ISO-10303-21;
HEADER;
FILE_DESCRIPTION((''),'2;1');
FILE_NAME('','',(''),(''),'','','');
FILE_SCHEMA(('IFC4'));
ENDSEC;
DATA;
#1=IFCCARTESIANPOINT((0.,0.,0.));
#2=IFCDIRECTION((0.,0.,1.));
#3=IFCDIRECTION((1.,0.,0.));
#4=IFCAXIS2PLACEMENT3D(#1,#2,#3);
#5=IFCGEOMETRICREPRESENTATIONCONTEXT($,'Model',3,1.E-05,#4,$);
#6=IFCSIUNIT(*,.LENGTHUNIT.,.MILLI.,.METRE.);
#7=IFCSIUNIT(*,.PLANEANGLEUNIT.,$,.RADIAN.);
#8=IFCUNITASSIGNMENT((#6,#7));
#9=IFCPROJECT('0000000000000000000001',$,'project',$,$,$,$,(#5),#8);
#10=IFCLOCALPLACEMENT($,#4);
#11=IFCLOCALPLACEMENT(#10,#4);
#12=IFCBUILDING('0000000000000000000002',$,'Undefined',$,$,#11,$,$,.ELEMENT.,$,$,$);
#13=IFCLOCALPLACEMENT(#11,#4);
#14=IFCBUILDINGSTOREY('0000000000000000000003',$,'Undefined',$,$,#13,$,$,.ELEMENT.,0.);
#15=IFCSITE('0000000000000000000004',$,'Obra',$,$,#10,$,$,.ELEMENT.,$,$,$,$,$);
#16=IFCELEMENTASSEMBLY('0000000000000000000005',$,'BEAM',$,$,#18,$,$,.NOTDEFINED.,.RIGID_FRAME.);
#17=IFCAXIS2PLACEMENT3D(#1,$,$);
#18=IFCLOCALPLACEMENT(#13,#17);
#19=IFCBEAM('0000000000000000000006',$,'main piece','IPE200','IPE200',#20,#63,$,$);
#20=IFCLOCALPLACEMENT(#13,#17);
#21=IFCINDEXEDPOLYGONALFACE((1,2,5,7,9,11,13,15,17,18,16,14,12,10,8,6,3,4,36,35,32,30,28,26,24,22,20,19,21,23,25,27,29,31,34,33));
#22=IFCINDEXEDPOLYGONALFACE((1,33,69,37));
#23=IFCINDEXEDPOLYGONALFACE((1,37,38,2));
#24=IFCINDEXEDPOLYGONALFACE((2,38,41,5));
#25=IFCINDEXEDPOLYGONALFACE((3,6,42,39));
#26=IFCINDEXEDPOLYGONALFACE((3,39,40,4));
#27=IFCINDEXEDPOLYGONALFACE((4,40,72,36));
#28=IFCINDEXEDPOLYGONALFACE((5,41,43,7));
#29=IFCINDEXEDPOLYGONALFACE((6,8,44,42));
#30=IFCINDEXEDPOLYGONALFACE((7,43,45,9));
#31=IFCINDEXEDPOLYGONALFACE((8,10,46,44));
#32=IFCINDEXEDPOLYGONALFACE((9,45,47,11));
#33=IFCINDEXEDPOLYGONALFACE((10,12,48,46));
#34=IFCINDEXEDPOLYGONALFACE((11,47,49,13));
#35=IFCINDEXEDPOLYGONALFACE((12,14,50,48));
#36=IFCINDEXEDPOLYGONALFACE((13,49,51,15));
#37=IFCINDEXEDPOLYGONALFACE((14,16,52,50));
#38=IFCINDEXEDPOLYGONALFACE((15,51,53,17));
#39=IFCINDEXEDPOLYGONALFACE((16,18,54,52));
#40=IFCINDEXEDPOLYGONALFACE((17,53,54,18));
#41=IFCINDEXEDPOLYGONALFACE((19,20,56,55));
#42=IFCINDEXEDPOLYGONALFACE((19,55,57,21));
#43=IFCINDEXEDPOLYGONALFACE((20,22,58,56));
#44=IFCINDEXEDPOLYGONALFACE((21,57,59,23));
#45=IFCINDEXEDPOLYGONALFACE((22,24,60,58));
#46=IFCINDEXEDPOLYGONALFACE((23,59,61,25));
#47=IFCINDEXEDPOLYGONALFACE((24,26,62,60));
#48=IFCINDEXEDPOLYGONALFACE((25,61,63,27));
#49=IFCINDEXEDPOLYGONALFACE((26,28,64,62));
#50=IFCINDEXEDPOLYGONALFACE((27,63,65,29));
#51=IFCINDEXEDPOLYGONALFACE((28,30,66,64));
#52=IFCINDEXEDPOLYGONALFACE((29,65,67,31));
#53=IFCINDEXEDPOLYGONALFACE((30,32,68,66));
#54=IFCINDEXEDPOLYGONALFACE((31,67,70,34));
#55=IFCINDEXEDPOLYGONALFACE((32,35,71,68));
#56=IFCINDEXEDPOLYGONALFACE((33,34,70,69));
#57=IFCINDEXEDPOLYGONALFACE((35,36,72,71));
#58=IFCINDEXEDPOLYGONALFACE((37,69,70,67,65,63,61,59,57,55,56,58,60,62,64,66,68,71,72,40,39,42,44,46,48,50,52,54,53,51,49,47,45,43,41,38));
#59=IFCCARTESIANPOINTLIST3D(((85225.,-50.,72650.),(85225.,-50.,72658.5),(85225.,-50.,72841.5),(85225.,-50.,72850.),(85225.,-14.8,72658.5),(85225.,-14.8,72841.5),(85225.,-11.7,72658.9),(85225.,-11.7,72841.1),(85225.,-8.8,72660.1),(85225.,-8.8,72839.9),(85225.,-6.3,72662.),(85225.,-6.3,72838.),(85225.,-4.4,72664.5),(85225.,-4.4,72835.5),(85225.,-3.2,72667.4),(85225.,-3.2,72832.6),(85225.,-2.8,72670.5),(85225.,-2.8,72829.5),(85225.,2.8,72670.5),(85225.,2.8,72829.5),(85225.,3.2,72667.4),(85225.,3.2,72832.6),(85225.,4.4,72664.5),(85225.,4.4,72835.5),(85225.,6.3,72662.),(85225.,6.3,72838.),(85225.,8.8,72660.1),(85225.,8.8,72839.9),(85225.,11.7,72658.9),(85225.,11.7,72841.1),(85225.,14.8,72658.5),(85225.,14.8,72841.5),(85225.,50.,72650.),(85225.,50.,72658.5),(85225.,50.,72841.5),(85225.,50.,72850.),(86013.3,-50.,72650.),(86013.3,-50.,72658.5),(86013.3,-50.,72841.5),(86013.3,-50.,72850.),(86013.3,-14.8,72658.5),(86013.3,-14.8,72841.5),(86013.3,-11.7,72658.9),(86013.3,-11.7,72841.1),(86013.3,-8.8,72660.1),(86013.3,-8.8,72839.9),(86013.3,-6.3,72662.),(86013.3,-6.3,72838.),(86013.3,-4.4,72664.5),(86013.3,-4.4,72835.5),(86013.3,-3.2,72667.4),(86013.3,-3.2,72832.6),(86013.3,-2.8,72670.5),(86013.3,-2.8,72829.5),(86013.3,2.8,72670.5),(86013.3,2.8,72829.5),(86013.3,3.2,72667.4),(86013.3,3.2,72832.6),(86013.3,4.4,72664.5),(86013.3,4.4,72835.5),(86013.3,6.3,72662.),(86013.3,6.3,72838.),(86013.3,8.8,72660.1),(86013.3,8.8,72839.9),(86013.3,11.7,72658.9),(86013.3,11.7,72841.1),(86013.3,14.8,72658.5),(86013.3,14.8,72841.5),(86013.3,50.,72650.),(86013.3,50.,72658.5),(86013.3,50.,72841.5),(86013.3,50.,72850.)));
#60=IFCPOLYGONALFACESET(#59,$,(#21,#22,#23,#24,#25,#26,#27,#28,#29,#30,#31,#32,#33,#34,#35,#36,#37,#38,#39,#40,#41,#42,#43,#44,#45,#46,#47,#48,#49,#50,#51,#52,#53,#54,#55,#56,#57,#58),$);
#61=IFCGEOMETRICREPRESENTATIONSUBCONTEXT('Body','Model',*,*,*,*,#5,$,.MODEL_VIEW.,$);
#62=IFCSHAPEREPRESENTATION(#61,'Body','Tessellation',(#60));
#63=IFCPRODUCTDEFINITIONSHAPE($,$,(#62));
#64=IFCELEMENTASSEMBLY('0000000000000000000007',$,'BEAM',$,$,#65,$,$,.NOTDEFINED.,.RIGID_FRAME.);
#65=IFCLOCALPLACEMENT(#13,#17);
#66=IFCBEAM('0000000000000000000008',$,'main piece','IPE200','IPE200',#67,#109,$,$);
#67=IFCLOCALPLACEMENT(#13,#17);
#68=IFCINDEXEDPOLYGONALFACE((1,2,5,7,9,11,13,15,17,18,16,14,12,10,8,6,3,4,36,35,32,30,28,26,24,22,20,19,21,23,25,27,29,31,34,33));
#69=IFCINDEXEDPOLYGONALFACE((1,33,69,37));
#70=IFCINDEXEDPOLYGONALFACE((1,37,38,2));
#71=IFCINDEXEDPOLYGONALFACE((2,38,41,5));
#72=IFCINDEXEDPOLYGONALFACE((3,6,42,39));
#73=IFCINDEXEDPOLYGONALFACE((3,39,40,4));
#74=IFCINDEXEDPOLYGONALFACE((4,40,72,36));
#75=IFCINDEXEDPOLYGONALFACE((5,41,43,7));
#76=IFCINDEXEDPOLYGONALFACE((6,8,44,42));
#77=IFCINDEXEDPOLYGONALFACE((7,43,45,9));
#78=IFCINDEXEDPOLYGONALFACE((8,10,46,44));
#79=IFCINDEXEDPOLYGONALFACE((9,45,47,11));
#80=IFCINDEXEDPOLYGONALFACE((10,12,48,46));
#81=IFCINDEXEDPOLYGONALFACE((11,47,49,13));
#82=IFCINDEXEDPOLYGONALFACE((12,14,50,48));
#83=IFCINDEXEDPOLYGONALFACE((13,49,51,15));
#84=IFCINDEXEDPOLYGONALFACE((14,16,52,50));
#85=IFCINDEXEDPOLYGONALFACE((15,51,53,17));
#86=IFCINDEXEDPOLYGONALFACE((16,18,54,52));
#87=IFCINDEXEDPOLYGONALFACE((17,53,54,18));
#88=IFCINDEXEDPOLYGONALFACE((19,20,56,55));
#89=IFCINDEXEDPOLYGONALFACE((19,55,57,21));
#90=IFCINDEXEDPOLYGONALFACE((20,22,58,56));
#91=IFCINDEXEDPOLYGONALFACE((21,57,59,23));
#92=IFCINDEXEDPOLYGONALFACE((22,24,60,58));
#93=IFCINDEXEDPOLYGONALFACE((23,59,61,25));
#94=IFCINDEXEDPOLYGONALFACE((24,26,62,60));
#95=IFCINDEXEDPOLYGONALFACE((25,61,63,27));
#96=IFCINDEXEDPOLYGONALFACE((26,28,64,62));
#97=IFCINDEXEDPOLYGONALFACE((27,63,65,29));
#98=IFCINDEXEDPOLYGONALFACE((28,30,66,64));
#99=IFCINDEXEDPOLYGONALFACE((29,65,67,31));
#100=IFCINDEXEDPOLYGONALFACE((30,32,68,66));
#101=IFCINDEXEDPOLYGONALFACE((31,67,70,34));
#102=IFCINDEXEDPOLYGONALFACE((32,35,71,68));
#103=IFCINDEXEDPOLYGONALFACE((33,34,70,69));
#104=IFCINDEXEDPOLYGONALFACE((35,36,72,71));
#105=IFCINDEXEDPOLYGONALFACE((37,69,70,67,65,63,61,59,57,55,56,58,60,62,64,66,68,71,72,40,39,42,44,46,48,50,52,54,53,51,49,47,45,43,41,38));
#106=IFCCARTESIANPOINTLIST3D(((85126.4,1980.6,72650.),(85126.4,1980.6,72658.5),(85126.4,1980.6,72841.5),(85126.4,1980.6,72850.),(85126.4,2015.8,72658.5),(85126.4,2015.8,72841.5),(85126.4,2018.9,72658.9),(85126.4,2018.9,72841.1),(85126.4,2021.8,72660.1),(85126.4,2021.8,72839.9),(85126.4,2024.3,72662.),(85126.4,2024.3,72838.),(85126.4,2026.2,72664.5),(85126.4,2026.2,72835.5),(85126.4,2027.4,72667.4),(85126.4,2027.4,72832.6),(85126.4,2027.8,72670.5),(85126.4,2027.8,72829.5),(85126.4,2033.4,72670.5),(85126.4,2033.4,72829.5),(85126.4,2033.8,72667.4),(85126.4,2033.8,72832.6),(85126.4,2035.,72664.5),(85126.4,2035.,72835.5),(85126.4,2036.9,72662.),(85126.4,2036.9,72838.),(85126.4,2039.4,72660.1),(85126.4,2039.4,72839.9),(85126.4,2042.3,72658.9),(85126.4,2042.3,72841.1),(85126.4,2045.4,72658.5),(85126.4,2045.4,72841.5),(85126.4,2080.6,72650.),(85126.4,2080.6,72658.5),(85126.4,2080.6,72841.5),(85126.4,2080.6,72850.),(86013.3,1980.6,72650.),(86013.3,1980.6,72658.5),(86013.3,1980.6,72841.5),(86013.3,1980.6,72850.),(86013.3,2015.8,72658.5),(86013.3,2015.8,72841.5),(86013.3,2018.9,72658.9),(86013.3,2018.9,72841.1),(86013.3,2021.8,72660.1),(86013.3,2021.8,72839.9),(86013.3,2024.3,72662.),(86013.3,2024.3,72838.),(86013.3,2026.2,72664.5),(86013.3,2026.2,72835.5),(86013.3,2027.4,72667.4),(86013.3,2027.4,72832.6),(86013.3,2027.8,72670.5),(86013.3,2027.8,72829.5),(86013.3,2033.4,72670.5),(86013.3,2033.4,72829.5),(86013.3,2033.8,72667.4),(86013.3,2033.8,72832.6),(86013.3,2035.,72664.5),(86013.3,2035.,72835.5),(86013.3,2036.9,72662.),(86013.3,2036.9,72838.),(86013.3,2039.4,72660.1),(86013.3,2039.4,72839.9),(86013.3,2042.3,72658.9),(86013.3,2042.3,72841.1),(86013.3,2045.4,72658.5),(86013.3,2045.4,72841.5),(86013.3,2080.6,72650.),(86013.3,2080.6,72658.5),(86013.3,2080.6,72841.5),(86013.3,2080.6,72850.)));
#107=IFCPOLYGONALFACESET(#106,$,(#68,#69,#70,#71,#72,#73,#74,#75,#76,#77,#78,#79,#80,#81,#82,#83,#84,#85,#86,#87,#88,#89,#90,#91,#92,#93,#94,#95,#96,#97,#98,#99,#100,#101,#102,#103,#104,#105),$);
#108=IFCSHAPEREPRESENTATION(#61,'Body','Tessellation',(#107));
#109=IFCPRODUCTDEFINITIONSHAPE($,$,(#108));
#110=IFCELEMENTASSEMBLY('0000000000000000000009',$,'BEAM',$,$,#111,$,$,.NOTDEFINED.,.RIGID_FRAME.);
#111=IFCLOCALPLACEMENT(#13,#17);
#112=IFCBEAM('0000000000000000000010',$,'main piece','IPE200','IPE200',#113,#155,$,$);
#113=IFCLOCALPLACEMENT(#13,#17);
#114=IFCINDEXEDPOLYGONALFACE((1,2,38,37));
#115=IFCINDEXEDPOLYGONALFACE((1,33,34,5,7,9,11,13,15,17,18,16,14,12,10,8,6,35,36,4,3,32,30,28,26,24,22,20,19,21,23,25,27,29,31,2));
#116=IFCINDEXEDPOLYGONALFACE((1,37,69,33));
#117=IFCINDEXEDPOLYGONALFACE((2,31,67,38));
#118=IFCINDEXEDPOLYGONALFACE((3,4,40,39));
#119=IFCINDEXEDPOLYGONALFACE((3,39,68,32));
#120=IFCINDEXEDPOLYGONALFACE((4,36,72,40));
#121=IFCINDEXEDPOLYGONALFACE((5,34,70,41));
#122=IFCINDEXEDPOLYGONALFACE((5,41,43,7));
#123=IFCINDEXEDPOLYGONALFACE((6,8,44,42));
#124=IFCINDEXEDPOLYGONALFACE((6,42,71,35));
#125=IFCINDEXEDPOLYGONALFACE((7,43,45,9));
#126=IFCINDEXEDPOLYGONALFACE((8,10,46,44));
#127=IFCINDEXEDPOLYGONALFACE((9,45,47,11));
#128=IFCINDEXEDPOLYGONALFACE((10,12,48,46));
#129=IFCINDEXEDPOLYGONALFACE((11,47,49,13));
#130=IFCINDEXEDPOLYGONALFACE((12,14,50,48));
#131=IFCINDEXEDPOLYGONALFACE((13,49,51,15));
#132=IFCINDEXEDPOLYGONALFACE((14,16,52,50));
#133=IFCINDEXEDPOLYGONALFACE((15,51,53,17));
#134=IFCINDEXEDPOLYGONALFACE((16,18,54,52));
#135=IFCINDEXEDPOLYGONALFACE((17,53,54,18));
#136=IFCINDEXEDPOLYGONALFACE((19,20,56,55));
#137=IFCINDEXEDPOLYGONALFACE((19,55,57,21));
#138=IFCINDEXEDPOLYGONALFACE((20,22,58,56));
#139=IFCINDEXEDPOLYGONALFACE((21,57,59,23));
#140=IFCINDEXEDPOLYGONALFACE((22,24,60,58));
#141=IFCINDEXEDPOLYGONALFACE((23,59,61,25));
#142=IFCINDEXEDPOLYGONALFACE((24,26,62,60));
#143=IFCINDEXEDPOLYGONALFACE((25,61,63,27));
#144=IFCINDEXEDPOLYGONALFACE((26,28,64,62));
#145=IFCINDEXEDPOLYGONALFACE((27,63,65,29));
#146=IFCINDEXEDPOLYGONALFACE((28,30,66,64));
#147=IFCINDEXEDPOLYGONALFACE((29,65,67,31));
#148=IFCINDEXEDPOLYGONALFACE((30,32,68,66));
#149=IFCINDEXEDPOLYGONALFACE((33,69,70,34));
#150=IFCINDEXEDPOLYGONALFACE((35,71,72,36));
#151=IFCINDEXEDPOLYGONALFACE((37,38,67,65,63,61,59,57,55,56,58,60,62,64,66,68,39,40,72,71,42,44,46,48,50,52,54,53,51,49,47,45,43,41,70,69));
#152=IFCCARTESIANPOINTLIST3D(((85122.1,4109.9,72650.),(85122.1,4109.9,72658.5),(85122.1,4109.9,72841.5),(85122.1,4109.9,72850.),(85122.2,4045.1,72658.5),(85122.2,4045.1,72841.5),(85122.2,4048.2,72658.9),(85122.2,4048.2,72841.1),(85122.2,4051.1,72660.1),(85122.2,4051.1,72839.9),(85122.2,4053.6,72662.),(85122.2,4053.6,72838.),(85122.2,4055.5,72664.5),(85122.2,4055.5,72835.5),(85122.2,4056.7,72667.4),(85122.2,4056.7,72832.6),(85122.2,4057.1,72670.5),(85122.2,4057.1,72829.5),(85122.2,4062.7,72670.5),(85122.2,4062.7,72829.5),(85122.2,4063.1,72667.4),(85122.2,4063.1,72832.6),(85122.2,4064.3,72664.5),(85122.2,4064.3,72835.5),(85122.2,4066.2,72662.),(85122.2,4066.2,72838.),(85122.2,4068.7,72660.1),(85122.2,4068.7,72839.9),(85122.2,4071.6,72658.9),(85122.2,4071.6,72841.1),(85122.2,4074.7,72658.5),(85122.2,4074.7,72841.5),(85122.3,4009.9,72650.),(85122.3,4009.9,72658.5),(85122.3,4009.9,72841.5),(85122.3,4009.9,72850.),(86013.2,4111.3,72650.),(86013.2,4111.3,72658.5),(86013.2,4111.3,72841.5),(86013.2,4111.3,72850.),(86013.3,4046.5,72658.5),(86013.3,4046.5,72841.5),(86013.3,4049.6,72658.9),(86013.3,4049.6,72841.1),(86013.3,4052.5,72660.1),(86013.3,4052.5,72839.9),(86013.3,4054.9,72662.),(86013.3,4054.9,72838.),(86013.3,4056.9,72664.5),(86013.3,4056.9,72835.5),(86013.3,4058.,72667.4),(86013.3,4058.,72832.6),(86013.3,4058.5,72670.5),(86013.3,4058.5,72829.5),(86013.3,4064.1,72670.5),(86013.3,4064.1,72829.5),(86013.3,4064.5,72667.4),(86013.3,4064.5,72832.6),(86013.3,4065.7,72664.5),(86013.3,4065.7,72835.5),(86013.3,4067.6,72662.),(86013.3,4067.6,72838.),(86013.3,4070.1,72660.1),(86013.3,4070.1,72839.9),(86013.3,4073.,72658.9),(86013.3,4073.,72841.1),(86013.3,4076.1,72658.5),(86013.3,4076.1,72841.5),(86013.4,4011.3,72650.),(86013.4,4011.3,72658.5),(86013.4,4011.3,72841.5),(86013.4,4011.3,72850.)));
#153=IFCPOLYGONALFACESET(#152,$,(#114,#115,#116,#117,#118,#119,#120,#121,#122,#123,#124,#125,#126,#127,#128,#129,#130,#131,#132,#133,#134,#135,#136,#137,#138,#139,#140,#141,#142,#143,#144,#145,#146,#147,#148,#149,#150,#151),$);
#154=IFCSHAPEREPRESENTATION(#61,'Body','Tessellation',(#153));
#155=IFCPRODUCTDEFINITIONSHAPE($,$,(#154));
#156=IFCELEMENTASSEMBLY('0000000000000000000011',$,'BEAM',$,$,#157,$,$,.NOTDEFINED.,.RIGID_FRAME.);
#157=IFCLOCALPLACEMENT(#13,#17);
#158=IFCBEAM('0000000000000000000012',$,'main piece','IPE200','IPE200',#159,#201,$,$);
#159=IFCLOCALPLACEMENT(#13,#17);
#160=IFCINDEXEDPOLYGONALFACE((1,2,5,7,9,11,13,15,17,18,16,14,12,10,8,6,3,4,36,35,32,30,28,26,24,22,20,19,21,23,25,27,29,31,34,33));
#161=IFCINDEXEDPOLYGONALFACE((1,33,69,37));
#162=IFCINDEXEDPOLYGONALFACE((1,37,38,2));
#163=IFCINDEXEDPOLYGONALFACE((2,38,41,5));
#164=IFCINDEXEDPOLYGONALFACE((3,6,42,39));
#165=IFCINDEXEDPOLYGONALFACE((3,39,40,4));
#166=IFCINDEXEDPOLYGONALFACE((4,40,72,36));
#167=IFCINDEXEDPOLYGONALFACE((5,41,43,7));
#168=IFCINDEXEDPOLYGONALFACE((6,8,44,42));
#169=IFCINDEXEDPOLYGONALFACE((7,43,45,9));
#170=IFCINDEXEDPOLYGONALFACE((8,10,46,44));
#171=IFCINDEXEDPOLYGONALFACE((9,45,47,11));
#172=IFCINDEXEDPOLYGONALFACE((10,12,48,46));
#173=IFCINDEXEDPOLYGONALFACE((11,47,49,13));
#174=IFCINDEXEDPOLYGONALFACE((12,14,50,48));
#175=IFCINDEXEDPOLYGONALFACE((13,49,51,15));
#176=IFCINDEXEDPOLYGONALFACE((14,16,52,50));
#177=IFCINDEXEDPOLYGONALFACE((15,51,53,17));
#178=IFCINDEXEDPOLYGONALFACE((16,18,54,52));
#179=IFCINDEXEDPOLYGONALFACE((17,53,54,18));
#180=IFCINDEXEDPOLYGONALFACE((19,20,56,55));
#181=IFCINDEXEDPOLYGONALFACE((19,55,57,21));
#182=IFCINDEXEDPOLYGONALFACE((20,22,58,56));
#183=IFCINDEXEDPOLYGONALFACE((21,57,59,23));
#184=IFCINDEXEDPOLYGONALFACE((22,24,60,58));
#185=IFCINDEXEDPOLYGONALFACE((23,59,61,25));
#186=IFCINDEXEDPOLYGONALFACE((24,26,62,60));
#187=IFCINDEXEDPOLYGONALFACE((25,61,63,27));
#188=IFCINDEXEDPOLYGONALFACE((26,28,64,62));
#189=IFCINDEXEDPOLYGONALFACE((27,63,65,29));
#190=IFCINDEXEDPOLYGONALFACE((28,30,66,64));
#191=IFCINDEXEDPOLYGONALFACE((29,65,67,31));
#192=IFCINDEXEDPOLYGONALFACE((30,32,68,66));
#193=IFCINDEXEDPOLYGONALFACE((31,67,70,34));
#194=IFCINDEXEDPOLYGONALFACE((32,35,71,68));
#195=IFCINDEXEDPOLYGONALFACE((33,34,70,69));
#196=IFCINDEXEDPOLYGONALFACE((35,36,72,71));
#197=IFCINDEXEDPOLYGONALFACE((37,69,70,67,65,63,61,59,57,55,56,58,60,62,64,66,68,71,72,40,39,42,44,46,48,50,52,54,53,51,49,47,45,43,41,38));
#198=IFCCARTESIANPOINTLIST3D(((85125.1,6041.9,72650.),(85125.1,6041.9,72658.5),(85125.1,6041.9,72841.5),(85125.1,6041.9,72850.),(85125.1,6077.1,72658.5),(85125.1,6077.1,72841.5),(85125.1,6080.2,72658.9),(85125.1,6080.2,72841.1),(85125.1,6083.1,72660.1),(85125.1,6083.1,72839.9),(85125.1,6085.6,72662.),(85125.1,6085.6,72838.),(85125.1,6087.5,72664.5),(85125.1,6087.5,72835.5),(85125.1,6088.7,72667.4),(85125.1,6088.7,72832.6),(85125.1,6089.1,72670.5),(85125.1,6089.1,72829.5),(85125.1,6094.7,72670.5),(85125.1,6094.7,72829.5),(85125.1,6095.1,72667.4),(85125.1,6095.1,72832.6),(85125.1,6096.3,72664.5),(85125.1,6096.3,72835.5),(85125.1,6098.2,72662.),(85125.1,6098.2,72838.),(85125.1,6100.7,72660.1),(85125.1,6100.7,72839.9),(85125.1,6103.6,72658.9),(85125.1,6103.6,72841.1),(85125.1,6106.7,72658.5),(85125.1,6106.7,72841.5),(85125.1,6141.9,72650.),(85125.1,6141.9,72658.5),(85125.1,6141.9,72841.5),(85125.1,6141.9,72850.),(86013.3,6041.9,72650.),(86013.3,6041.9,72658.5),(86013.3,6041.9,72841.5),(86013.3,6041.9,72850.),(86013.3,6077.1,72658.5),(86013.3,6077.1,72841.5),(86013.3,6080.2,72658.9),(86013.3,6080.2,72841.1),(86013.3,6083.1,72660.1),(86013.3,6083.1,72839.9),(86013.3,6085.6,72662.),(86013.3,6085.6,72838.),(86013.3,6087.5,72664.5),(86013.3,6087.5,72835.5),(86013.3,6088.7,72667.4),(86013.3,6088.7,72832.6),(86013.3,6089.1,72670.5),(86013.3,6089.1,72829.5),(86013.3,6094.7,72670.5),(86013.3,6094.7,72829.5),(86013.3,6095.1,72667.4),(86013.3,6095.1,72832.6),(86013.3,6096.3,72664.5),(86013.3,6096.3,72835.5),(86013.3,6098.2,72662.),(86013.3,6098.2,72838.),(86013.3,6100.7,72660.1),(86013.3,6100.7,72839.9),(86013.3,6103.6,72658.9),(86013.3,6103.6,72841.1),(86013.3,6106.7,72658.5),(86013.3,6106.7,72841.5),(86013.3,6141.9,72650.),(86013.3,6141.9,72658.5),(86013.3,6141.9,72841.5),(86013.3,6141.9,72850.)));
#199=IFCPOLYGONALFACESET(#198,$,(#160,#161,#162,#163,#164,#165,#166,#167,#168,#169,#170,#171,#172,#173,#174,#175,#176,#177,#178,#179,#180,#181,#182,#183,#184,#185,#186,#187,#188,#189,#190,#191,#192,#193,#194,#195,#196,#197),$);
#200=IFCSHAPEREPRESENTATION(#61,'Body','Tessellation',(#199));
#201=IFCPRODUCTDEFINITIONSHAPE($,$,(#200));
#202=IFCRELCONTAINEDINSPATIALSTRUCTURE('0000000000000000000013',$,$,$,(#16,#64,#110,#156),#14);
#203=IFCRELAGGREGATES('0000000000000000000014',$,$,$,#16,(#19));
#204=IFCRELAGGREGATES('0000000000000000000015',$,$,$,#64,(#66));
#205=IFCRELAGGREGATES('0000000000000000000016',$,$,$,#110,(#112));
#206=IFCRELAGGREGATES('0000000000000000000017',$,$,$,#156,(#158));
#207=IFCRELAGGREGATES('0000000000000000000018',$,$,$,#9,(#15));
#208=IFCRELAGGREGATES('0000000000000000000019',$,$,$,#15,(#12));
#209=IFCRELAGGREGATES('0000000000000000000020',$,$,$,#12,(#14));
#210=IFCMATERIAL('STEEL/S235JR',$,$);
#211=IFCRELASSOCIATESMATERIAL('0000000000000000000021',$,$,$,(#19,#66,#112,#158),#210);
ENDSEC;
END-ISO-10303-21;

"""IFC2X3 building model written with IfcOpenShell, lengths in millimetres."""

from ifc_helpers import new_model, si_unit, frame, origin_with_axes, origin_2d_with_axis, place, context, subcontext, project, spatial, i_section, extrude, material, element, aggregate, save


model = new_model("IFC2X3")

# Units and contexts
model_context = context("Model", 3, precision=1e-05, world=origin_with_axes())
body_context = subcontext(model_context, "Body", "Model", "MODEL_VIEW")
ifc_project = project(units=[si_unit("LENGTHUNIT", "METRE", prefix="MILLI"), si_unit("PLANEANGLEUNIT", "RADIAN")], contexts=[model_context])

# Site, building, storey
site_placement = place(None, origin_with_axes())
site = spatial("IfcSite", under=ifc_project, at=site_placement, Name="Obra", CompositionType="ELEMENT")
building_placement = place(site_placement, origin_with_axes())
building = spatial("IfcBuilding", under=site, at=building_placement, Name="Undefined", CompositionType="ELEMENT")
storey_placement = place(building_placement, origin_with_axes())
storey = spatial("IfcBuildingStorey", under=building, at=storey_placement, Name="Undefined", CompositionType="ELEMENT", Elevation=0.0)

# Element assemblies, beams
ifc_material = material(Name="STEEL/S235JR")
assembly_1_placement = place(storey_placement, origin_with_axes())
assembly_1 = element("IfcElementAssembly", 1, at=assembly_1_placement, inside=storey, Name="BEAM", AssemblyPlace="NOTDEFINED", PredefinedType="RIGID_FRAME")
beam_1_placement = place(assembly_1_placement, frame((85225.0, 0.0, 72750.0), z_axis=(0.0, 0.0, 1.0), x_axis=(1.0, 0.0, 0.0)))
beam_1 = element("IfcBeam", 2, at=beam_1_placement, material=ifc_material, Name="main piece", Description="IPE200", ObjectType="IPE200", context=body_context, shape_type="SweptSolid", body=[
    extrude(i_section(OverallWidth=100.0, OverallDepth=200.0, WebThickness=5.6, FlangeThickness=8.5, FilletRadius=12.0, at=origin_2d_with_axis()), frame((788.3, 0.0, 0.0), z_axis=(-1.0, 0.0, 0.0), x_axis=(0.0, -1.0, 0.0)), (0.0, 0.0, 1.0), 788.3),
])
aggregate(assembly_1, [beam_1])
assembly_2_placement = place(storey_placement, origin_with_axes())
assembly_2 = element("IfcElementAssembly", 3, at=assembly_2_placement, inside=storey, Name="BEAM", AssemblyPlace="NOTDEFINED", PredefinedType="RIGID_FRAME")
beam_2_placement = place(assembly_2_placement, frame((85126.4, 2030.6, 72750.0), z_axis=(0.0, 0.0, 1.0), x_axis=(1.0, 0.0, 0.0)))
beam_2 = element("IfcBeam", 4, at=beam_2_placement, material=ifc_material, Name="main piece", Description="IPE200", ObjectType="IPE200", context=body_context, shape_type="SweptSolid", body=[
    extrude(i_section(OverallWidth=100.0, OverallDepth=200.0, WebThickness=5.6, FlangeThickness=8.5, FilletRadius=12.0, at=origin_2d_with_axis()), frame((886.9, 0.0, 0.0), z_axis=(-1.0, 0.0, 0.0), x_axis=(0.0, -1.0, 0.0)), (0.0, 0.0, 1.0), 886.9),
])
aggregate(assembly_2, [beam_2])
assembly_3_placement = place(storey_placement, origin_with_axes())
assembly_3 = element("IfcElementAssembly", 5, at=assembly_3_placement, inside=storey, Name="BEAM", AssemblyPlace="NOTDEFINED", PredefinedType="RIGID_FRAME")
beam_3_placement = place(assembly_3_placement, frame((85122.2, 4059.9, 72750.0), z_axis=(0.0, 0.0, 1.0), x_axis=(0.999999, 0.001525, 0.0)))
beam_3 = element("IfcBeam", 6, at=beam_3_placement, material=ifc_material, Name="main piece", Description="IPE200", ObjectType="IPE200", context=body_context, shape_type="SweptSolid", body=[
    extrude(i_section(OverallWidth=100.0, OverallDepth=200.0, WebThickness=5.6, FlangeThickness=8.5, FilletRadius=12.0, at=origin_2d_with_axis()), frame((891.1, 0.0, 0.0), z_axis=(-1.0, 0.0, 0.0), x_axis=(0.0, -1.0, 0.0)), (0.0, 0.0, 1.0), 891.1),
])
aggregate(assembly_3, [beam_3])
assembly_4_placement = place(storey_placement, origin_with_axes())
assembly_4 = element("IfcElementAssembly", 7, at=assembly_4_placement, inside=storey, Name="BEAM", AssemblyPlace="NOTDEFINED", PredefinedType="RIGID_FRAME")
beam_4_placement = place(assembly_4_placement, frame((85125.0, 6091.9, 72750.0), z_axis=(0.0, 0.0, 1.0), x_axis=(1.0, 0.0, 0.0)))
beam_4 = element("IfcBeam", 8, at=beam_4_placement, material=ifc_material, Name="main piece", Description="IPE200", ObjectType="IPE200", context=body_context, shape_type="SweptSolid", body=[
    extrude(i_section(OverallWidth=100.0, OverallDepth=200.0, WebThickness=5.6, FlangeThickness=8.5, FilletRadius=12.0, at=origin_2d_with_axis()), frame((888.3, 0.0, 0.0), z_axis=(-1.0, 0.0, 0.0), x_axis=(0.0, -1.0, 0.0)), (0.0, 0.0, 1.0), 888.2),
])
aggregate(assembly_4, [beam_4])

save(model, "model.ifc")
